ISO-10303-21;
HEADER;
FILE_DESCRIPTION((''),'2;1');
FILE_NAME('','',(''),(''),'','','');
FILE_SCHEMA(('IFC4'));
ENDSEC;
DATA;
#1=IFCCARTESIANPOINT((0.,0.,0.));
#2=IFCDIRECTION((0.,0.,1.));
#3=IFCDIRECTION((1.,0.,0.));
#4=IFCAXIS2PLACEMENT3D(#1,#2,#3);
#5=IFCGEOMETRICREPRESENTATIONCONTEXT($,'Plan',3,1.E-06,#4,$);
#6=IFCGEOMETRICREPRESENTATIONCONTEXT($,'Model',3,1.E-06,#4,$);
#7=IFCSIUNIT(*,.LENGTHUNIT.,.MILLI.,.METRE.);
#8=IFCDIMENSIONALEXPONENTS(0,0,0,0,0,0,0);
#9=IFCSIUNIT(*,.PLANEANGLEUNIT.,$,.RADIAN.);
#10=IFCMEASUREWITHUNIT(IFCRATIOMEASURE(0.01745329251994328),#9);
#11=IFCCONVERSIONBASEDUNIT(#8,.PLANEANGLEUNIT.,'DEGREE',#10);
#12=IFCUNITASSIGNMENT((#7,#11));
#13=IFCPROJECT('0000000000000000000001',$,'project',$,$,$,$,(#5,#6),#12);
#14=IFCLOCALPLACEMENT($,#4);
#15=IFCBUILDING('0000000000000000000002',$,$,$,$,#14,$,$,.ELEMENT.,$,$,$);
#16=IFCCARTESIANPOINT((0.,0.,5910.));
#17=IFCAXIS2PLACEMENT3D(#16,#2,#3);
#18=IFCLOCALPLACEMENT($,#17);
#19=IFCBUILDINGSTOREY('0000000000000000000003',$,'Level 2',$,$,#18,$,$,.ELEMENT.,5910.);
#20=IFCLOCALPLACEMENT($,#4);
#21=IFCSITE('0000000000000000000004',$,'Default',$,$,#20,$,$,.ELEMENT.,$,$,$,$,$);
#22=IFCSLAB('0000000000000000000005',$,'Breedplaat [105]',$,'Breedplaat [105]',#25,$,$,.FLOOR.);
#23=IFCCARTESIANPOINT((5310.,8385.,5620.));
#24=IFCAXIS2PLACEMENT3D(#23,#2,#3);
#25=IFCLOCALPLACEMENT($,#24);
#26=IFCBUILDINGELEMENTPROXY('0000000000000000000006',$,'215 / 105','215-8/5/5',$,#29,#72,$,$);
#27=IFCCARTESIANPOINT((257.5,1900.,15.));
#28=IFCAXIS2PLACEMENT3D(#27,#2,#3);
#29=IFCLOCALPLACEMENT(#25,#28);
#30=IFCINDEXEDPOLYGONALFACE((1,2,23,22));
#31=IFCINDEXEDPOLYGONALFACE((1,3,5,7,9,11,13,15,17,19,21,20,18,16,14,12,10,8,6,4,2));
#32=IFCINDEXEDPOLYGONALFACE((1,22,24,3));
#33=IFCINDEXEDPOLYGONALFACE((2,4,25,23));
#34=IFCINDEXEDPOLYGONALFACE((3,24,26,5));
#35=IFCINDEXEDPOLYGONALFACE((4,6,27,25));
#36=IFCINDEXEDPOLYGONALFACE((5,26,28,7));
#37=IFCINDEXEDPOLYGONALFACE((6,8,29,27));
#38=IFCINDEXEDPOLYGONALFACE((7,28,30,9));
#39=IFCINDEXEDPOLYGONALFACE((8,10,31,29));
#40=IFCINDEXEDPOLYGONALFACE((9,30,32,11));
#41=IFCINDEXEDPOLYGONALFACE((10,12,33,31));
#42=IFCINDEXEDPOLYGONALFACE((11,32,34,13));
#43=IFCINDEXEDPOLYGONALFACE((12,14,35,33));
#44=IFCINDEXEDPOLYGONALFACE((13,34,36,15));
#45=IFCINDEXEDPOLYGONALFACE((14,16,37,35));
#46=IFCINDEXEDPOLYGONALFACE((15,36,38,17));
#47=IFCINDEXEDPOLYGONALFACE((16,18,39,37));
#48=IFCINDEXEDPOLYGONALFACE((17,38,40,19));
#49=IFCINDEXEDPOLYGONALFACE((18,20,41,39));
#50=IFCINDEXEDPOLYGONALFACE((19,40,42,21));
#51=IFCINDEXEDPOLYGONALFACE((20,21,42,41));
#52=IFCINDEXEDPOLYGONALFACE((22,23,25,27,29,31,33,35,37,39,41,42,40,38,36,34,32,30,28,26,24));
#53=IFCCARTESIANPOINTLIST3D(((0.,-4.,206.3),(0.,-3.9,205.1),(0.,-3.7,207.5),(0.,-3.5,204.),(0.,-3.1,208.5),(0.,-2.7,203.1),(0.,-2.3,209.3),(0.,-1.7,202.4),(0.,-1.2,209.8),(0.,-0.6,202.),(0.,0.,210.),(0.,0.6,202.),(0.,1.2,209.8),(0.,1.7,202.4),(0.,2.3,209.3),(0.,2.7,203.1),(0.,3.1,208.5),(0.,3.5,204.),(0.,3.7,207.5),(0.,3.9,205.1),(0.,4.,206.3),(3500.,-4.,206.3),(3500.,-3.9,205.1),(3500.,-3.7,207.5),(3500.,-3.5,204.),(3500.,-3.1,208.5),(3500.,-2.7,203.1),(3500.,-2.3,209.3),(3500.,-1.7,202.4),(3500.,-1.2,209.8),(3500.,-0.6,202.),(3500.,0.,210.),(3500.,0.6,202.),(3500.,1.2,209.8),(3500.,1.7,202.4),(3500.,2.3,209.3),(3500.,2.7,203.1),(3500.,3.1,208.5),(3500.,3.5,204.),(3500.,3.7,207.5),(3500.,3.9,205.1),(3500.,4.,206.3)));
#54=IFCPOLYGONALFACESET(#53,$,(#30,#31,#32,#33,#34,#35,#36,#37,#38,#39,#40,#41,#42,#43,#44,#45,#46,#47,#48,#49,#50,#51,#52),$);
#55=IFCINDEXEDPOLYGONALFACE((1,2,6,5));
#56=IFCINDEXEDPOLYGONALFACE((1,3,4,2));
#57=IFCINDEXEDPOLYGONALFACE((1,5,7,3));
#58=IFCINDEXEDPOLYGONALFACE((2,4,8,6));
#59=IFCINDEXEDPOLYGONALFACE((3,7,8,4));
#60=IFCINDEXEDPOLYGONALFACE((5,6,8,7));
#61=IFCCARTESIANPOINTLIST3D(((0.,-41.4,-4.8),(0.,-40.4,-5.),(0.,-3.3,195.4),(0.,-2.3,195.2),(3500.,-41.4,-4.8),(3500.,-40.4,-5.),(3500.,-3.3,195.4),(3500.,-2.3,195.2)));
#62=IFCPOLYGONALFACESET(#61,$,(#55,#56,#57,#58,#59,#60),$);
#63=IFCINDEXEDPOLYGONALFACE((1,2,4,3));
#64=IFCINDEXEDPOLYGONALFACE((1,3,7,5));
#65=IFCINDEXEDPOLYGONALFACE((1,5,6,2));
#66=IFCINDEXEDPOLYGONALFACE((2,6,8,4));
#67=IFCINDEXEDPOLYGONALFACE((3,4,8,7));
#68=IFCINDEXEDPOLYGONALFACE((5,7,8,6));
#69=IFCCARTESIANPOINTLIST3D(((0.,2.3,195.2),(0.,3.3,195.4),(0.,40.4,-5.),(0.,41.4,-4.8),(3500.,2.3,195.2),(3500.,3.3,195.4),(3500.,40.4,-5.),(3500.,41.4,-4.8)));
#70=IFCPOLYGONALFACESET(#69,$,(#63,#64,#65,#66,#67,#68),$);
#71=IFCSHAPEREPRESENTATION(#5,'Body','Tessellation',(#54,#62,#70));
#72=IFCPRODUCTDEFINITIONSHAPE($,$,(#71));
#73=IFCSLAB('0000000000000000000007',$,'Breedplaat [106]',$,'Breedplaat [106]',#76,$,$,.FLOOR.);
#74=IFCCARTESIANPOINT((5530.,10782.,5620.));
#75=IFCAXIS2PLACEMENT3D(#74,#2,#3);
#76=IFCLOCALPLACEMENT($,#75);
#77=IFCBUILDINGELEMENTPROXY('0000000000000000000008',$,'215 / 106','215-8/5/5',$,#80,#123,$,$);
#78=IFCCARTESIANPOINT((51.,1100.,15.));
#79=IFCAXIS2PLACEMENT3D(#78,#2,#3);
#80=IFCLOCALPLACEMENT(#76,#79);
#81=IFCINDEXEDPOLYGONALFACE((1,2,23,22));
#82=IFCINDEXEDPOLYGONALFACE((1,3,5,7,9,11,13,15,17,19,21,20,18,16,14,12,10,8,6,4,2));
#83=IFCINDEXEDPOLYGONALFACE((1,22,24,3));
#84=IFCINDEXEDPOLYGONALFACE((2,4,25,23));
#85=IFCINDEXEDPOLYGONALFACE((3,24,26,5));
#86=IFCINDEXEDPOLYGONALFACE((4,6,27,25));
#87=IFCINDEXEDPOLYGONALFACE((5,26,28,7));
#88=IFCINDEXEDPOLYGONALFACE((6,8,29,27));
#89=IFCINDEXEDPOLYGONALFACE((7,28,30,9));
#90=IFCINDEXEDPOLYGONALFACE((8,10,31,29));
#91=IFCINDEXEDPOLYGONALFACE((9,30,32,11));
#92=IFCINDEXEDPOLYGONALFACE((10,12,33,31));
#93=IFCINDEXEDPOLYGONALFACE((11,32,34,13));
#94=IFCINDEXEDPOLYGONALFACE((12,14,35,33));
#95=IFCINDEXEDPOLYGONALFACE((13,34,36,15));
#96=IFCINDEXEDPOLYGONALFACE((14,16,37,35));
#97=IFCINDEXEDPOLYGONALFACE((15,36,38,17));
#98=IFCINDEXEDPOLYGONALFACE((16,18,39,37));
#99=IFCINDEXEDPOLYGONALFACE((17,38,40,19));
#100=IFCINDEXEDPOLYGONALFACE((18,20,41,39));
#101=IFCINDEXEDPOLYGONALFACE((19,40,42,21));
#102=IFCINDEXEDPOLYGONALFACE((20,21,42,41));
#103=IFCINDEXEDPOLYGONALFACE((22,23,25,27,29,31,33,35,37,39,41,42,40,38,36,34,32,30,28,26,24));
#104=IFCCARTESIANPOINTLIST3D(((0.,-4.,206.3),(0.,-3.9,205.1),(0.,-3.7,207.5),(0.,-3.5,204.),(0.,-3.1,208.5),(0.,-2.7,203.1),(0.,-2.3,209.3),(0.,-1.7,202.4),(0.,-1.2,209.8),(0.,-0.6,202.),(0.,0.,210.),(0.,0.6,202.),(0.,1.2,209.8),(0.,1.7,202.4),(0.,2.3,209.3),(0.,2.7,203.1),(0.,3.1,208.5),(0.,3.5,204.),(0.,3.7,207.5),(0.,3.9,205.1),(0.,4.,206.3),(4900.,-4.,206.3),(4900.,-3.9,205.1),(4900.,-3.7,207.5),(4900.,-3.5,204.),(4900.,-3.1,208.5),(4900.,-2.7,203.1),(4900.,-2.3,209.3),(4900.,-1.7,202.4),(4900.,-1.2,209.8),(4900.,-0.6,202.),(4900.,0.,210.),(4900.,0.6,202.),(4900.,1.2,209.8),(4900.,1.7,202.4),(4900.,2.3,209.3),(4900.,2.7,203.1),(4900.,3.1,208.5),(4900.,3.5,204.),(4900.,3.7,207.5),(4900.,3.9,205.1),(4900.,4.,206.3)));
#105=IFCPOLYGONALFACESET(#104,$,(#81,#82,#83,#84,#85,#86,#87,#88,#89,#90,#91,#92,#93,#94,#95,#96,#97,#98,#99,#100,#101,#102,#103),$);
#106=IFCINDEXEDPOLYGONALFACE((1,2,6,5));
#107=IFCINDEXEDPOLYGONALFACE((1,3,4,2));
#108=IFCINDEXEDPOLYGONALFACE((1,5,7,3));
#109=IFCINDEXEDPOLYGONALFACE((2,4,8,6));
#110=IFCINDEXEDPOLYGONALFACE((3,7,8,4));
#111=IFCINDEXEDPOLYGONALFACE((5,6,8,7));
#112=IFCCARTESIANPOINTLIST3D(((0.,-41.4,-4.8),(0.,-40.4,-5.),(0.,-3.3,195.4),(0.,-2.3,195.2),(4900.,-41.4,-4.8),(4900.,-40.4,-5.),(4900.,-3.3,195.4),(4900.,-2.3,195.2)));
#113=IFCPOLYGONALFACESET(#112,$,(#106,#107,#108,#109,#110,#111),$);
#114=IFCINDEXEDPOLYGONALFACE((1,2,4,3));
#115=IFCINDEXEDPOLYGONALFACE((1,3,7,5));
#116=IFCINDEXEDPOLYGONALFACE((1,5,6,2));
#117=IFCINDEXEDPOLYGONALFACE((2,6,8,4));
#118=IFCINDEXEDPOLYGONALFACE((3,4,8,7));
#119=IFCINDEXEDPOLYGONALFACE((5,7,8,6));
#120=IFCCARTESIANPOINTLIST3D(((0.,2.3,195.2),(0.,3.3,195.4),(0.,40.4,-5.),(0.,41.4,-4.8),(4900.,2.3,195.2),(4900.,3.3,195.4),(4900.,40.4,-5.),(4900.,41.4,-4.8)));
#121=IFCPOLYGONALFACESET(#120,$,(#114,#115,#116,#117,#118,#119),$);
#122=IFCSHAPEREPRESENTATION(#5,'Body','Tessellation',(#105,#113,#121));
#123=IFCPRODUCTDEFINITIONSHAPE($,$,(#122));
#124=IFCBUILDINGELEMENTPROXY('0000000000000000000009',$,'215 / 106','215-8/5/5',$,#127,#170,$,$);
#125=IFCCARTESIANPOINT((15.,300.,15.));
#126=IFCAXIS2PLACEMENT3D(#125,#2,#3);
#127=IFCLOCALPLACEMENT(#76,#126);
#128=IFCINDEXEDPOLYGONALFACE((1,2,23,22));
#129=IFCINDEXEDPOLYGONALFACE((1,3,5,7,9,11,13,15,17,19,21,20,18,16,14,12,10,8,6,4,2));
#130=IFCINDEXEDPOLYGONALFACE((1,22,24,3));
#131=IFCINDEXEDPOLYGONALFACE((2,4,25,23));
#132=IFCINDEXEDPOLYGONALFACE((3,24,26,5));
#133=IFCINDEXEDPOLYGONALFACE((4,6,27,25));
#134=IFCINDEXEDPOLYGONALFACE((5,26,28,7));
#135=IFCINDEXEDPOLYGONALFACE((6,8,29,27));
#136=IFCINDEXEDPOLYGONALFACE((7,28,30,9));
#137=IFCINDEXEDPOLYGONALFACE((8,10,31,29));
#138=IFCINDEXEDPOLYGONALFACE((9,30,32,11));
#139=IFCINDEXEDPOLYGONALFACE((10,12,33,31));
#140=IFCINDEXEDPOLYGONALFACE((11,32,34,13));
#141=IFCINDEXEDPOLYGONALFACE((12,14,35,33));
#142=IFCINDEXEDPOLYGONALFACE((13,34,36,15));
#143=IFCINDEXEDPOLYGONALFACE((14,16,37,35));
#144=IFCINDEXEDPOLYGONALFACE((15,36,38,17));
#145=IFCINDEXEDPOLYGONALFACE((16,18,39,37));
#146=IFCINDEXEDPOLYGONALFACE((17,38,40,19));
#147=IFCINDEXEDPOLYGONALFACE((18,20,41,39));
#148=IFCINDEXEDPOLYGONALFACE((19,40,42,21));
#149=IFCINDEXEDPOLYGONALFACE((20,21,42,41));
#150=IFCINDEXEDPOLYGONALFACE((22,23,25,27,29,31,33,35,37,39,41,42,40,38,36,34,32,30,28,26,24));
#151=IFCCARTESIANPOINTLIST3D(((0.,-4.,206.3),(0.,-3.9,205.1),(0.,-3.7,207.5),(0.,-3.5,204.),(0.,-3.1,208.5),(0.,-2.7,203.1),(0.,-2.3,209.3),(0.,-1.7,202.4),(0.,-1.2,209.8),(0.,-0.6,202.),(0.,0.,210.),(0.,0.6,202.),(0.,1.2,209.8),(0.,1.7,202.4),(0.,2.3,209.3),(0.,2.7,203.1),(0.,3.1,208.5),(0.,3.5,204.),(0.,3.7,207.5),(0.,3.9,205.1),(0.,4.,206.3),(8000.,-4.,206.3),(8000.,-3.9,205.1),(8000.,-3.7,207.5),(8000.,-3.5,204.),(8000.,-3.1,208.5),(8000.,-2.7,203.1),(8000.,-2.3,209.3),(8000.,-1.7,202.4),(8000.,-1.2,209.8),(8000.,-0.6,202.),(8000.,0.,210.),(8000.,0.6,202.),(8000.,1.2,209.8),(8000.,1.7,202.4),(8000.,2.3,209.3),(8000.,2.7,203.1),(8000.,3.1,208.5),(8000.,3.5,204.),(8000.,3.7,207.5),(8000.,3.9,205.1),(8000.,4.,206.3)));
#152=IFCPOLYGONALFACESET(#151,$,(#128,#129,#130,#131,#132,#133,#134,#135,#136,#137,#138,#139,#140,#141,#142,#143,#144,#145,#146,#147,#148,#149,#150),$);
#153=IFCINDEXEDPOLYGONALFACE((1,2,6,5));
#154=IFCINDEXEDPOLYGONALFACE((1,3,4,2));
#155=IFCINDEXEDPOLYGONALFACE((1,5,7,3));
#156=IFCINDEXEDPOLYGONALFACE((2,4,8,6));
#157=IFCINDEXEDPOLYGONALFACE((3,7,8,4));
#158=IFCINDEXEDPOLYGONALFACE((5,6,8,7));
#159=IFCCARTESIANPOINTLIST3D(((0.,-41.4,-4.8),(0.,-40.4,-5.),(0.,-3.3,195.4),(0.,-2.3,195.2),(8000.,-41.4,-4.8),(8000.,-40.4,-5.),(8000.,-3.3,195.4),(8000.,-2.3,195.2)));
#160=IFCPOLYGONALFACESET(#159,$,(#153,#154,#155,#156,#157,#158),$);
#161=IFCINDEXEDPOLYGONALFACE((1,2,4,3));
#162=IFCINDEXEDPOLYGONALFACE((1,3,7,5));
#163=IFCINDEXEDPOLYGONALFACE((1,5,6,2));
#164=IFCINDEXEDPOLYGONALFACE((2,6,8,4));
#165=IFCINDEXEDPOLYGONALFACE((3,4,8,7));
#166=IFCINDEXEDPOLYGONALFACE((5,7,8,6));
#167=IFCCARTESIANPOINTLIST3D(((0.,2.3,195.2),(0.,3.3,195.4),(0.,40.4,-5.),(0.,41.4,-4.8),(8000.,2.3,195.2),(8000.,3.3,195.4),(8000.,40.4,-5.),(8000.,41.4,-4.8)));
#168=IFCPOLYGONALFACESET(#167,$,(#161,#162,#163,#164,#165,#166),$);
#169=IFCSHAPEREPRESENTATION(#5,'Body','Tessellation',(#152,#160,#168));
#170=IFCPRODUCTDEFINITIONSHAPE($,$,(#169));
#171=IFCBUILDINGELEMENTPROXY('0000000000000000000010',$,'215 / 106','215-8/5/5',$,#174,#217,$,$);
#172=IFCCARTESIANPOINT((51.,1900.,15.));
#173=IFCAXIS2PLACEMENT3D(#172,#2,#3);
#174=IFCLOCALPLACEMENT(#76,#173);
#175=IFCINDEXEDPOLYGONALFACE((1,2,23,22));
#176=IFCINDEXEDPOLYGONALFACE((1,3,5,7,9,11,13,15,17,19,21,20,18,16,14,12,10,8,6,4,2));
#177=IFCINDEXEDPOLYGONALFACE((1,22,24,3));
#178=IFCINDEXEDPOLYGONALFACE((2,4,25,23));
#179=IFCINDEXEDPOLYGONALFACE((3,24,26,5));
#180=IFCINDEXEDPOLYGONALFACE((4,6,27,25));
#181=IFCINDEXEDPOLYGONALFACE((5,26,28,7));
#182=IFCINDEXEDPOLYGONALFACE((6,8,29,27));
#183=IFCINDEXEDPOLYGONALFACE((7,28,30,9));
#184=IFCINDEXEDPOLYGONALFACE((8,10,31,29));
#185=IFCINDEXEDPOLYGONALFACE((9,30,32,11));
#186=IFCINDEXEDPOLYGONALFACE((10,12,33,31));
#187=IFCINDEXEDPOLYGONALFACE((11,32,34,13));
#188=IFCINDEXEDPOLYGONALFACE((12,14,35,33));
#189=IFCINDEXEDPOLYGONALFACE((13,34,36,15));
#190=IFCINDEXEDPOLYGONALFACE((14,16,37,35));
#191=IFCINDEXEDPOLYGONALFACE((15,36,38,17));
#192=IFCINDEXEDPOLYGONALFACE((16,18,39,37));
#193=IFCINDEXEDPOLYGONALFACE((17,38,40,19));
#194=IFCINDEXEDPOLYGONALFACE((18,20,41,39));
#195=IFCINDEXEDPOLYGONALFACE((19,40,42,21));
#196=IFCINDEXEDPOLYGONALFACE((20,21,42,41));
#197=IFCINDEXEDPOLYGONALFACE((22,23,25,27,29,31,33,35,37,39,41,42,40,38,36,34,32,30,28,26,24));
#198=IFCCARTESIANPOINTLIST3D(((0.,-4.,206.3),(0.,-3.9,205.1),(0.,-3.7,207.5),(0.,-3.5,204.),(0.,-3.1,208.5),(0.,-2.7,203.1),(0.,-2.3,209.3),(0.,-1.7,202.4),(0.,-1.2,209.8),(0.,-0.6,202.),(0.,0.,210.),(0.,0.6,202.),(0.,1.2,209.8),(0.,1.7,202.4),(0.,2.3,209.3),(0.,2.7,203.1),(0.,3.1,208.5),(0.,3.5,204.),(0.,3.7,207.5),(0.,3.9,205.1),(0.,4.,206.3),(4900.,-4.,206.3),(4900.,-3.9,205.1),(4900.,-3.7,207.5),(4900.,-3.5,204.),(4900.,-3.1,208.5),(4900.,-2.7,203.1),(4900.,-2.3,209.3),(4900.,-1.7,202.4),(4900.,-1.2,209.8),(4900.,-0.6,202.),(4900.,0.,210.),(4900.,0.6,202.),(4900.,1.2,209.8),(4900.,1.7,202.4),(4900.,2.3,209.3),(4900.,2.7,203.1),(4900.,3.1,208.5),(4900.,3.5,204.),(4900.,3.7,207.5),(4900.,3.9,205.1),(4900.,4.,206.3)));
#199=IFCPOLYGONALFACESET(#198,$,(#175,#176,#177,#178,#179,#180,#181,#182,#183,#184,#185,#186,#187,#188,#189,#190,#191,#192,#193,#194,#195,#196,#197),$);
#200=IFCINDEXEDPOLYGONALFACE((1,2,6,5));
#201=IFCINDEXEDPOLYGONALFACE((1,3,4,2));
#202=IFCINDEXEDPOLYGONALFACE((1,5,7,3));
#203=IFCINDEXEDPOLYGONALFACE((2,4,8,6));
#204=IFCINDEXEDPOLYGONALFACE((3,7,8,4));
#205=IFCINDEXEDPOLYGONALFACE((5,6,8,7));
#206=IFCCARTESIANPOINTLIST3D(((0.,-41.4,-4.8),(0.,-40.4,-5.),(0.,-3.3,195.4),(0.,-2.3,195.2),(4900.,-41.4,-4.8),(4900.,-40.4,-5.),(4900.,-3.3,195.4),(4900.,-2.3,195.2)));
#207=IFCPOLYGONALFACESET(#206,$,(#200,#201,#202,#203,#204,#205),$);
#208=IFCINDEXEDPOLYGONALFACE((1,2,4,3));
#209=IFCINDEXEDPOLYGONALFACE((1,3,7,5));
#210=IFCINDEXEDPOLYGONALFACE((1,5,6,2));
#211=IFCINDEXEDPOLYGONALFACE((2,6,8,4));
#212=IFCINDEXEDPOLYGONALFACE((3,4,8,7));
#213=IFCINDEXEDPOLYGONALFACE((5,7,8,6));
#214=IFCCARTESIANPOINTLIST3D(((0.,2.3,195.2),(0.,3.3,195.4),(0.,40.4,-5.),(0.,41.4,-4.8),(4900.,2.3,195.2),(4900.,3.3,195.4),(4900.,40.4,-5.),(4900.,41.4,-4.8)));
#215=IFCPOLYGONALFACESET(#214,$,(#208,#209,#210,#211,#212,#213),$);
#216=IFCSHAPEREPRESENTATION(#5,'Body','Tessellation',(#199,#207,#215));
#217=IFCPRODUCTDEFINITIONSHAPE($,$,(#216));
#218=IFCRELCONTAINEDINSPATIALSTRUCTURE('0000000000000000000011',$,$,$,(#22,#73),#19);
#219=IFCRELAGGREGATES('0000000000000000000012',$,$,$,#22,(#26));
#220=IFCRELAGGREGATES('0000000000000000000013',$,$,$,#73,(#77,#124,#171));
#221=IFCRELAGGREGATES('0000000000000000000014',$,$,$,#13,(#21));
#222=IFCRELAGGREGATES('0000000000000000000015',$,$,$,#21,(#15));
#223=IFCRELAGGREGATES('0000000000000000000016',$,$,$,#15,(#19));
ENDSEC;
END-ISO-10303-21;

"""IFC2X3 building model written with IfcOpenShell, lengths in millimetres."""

from ifc_helpers import new_model, entity, si_unit, converted_unit, frame, origin_with_axes, origin_2d_with_axis, place, context, project, spatial, rectangle, circle, extrude, element, aggregate, save


model = new_model("IFC2X3")

# Units and contexts
plan_context = context("Plan", 3, precision=1e-06, world=origin_with_axes())
model_context = context("Model", 3, precision=1e-06, world=origin_with_axes())
ifc_project = project(units=[si_unit("LENGTHUNIT", "METRE", prefix="MILLI"), converted_unit("PLANEANGLEUNIT", "DEGREE", entity("IfcRatioMeasure", 0.01745329251994328), si_unit("PLANEANGLEUNIT", "RADIAN"), dimensions=[0, 0, 0, 0, 0, 0, 0])], contexts=[plan_context, model_context])

# Site, building, storey
site_placement = place(None, origin_with_axes())
site = spatial("IfcSite", under=ifc_project, at=site_placement, Name="Default", CompositionType="ELEMENT")
building_placement = place(None, origin_with_axes())
building = spatial("IfcBuilding", under=site, at=building_placement, CompositionType="ELEMENT")
storey_placement = place(None, frame((0.0, 0.0, 5910.0), z_axis=(0.0, 0.0, 1.0), x_axis=(1.0, 0.0, 0.0)))
storey = spatial("IfcBuildingStorey", under=building, at=storey_placement, Name="Level 2", CompositionType="ELEMENT", Elevation=5910.0)

# Slab, building element proxy
slab_1_placement = place(None, frame((5310.0, 8385.0, 5620.0), z_axis=(0.0, 0.0, 1.0), x_axis=(1.0, 0.0, 0.0)))
slab_1 = element("IfcSlab", 1, at=slab_1_placement, inside=storey, Name="Breedplaat [105]", ObjectType="Breedplaat [105]", PredefinedType="FLOOR")
proxy_1_placement = place(slab_1_placement, frame((257.5, 1900.0, 15.0), z_axis=(0.0, 0.0, 1.0), x_axis=(1.0, 0.0, 0.0)))
proxy_1 = element("IfcBuildingElementProxy", 2, at=proxy_1_placement, Name="215 / 105", Description="215-8/5/5", context=plan_context, shape_type="SweptSolid", body=[
    extrude(circle(Radius=4.0, at=origin_2d_with_axis()), frame((0.0, 0.0, 206.0), z_axis=(1.0, 0.0, 0.0), x_axis=(0.0, 0.0, 1.0)), (0.0, 0.0, 1.0), 3500.0),
    extrude(rectangle(XDim=203.8, YDim=1.0, at=origin_2d_with_axis()), frame((0.0, -21.9, 95.2), z_axis=(1.0, 0.0, 0.0), x_axis=(0.0, 0.187112, 0.982339)), (0.0, 0.0, 1.0), 3500.0),
    extrude(rectangle(XDim=203.8, YDim=1.0, at=origin_2d_with_axis()), frame((0.0, 21.9, 95.2), z_axis=(1.0, 0.0, 0.0), x_axis=(0.0, -0.187112, 0.982339)), (0.0, 0.0, 1.0), 3500.0),
])
aggregate(slab_1, [proxy_1])

# Slab, building element proxies
slab_2_placement = place(None, frame((5530.0, 10782.0, 5620.0), z_axis=(0.0, 0.0, 1.0), x_axis=(1.0, 0.0, 0.0)))
slab_2 = element("IfcSlab", 3, at=slab_2_placement, inside=storey, Name="Breedplaat [106]", ObjectType="Breedplaat [106]", PredefinedType="FLOOR")
proxy_2_placement = place(slab_2_placement, frame((51.0, 1100.0, 15.0), z_axis=(0.0, 0.0, 1.0), x_axis=(1.0, 0.0, 0.0)))
proxy_2 = element("IfcBuildingElementProxy", 4, at=proxy_2_placement, Name="215 / 106", Description="215-8/5/5", context=plan_context, shape_type="SweptSolid", body=[
    extrude(circle(Radius=4.0, at=origin_2d_with_axis()), frame((0.0, 0.0, 206.0), z_axis=(1.0, 0.0, 0.0), x_axis=(0.0, 0.0, 1.0)), (0.0, 0.0, 1.0), 4900.0),
    extrude(rectangle(XDim=203.8, YDim=1.0, at=origin_2d_with_axis()), frame((0.0, -21.9, 95.2), z_axis=(1.0, 0.0, 0.0), x_axis=(0.0, 0.187112, 0.982339)), (0.0, 0.0, 1.0), 4900.0),
    extrude(rectangle(XDim=203.8, YDim=1.0, at=origin_2d_with_axis()), frame((0.0, 21.9, 95.2), z_axis=(1.0, 0.0, 0.0), x_axis=(0.0, -0.187112, 0.982339)), (0.0, 0.0, 1.0), 4900.0),
])
proxy_3_placement = place(slab_2_placement, frame((15.0, 300.0, 15.0), z_axis=(0.0, 0.0, 1.0), x_axis=(1.0, 0.0, 0.0)))
proxy_3 = element("IfcBuildingElementProxy", 5, at=proxy_3_placement, Name="215 / 106", Description="215-8/5/5", context=plan_context, shape_type="SweptSolid", body=[
    extrude(circle(Radius=4.0, at=origin_2d_with_axis()), frame((0.0, 0.0, 206.0), z_axis=(1.0, 0.0, 0.0), x_axis=(0.0, 0.0, 1.0)), (0.0, 0.0, 1.0), 8000.0),
    extrude(rectangle(XDim=203.8, YDim=1.0, at=origin_2d_with_axis()), frame((0.0, -21.9, 95.2), z_axis=(1.0, 0.0, 0.0), x_axis=(0.0, 0.187112, 0.982339)), (0.0, 0.0, 1.0), 8000.0),
    extrude(rectangle(XDim=203.8, YDim=1.0, at=origin_2d_with_axis()), frame((0.0, 21.9, 95.2), z_axis=(1.0, 0.0, 0.0), x_axis=(0.0, -0.187112, 0.982339)), (0.0, 0.0, 1.0), 8000.0),
])
proxy_4_placement = place(slab_2_placement, frame((51.0, 1900.0, 15.0), z_axis=(0.0, 0.0, 1.0), x_axis=(1.0, 0.0, 0.0)))
proxy_4 = element("IfcBuildingElementProxy", 6, at=proxy_4_placement, Name="215 / 106", Description="215-8/5/5", context=plan_context, shape_type="SweptSolid", body=[
    extrude(circle(Radius=4.0, at=origin_2d_with_axis()), frame((0.0, 0.0, 206.0), z_axis=(1.0, 0.0, 0.0), x_axis=(0.0, 0.0, 1.0)), (0.0, 0.0, 1.0), 4900.0),
    extrude(rectangle(XDim=203.8, YDim=1.0, at=origin_2d_with_axis()), frame((0.0, -21.9, 95.2), z_axis=(1.0, 0.0, 0.0), x_axis=(0.0, 0.187112, 0.982339)), (0.0, 0.0, 1.0), 4900.0),
    extrude(rectangle(XDim=203.8, YDim=1.0, at=origin_2d_with_axis()), frame((0.0, 21.9, 95.2), z_axis=(1.0, 0.0, 0.0), x_axis=(0.0, -0.187112, 0.982339)), (0.0, 0.0, 1.0), 4900.0),
])
aggregate(slab_2, [proxy_2, proxy_3, proxy_4])

save(model, "model.ifc")
